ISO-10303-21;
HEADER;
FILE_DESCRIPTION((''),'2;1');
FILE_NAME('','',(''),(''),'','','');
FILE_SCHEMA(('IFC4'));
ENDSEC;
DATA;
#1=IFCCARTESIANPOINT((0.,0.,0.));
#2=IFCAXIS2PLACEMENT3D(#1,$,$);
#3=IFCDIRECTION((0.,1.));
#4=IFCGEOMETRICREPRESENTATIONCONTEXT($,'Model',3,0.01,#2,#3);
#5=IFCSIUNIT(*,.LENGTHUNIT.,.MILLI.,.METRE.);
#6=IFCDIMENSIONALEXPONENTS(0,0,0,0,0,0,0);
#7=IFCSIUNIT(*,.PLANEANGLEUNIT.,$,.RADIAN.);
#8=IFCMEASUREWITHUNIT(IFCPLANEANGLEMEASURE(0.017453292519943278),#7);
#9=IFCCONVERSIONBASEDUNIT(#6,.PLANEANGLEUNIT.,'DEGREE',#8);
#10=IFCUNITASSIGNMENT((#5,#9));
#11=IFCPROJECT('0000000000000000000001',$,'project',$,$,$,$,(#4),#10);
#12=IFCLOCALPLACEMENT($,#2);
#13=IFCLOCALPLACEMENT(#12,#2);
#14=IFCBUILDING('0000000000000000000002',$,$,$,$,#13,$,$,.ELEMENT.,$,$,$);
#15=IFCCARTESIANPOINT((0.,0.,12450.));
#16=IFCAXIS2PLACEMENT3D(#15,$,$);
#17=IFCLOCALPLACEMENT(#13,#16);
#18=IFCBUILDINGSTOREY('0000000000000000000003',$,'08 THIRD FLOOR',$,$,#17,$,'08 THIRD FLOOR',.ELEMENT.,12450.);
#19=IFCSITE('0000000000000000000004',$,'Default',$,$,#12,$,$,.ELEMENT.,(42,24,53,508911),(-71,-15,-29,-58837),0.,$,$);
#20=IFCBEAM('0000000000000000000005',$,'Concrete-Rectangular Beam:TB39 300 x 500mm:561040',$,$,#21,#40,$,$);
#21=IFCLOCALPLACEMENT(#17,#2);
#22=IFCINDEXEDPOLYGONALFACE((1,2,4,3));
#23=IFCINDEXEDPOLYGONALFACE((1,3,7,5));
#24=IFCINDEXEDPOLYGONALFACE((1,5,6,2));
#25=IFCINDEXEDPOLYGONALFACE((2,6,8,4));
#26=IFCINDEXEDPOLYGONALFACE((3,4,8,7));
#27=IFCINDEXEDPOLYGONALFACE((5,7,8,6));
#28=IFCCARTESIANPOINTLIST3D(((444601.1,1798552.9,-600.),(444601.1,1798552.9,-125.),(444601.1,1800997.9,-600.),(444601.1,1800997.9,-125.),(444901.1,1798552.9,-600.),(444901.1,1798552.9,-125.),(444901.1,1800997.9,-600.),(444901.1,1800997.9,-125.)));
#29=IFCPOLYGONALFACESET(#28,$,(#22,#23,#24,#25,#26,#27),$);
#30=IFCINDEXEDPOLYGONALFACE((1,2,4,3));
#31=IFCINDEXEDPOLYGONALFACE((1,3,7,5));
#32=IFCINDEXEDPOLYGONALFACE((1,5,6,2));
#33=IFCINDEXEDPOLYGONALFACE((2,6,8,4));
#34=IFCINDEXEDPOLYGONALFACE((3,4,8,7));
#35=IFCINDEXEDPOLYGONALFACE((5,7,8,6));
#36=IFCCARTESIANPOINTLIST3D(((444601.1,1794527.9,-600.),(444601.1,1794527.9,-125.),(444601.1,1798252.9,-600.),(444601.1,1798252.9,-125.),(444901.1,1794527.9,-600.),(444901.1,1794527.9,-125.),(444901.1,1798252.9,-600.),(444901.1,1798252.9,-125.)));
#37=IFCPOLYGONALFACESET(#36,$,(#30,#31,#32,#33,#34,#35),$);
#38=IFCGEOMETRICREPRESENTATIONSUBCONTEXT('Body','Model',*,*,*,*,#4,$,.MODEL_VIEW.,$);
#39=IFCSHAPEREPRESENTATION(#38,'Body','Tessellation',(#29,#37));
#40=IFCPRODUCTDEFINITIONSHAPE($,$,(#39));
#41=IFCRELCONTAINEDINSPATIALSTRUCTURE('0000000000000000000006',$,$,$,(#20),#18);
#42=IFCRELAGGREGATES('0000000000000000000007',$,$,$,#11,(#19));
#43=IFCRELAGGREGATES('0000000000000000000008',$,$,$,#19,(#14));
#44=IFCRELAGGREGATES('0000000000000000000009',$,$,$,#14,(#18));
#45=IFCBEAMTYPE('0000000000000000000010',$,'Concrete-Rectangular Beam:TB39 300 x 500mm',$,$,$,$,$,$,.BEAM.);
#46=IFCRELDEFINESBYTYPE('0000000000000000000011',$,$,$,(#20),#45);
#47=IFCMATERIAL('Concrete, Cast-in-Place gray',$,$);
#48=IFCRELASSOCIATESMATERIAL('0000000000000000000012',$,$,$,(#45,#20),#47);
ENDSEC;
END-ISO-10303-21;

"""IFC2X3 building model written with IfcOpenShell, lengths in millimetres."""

from ifc_helpers import new_model, entity, si_unit, converted_unit, direction, frame, frame_2d, origin, place, context, subcontext, project, spatial, rectangle, extrude, source, transform, mapped, material, type_object, type_shapes, element, save


model = new_model("IFC2X3")

# Units and contexts
model_context = context("Model", 3, precision=0.01, world=origin(), true_north=direction((0.0, 1.0)))
body_context = subcontext(model_context, "Body", "Model", "MODEL_VIEW")
ifc_project = project(units=[si_unit("LENGTHUNIT", "METRE", prefix="MILLI"), converted_unit("PLANEANGLEUNIT", "DEGREE", entity("IfcPlaneAngleMeasure", 0.017453292519943278), si_unit("PLANEANGLEUNIT", "RADIAN"), dimensions=[0, 0, 0, 0, 0, 0, 0])], contexts=[model_context])

# Site, building, storey
site_placement = place(None, origin())
site = spatial("IfcSite", under=ifc_project, at=site_placement, Name="Default", CompositionType="ELEMENT", RefLatitude=(42, 24, 53, 508911), RefLongitude=(-71, -15, -29, -58837), RefElevation=0.0)
building_placement = place(site_placement, origin())
building = spatial("IfcBuilding", under=site, at=building_placement, CompositionType="ELEMENT")
storey_placement = place(building_placement, frame((0.0, 0.0, 12450.0)))
storey = spatial("IfcBuildingStorey", under=building, at=storey_placement, Name="08 THIRD FLOOR", LongName="08 THIRD FLOOR", CompositionType="ELEMENT", Elevation=12450.0)

# Shared definitions
ifc_material = material(Name="Concrete, Cast-in-Place gray")

# Beam
beam_type_1 = type_object("IfcBeamType", Name="Concrete-Rectangular Beam:TB39 300 x 500mm", PredefinedType="BEAM", material=ifc_material)
shared_shape_1 = source(origin(), body_context, "Body", "SweptSolid", [
    extrude(rectangle(XDim=475.0, YDim=300.0, at=frame_2d((0.0, 0.0), x_axis=(0.0, 1.0))), frame((444751.1, 1800997.9, 12087.5), z_axis=(0.0, -1.0, 0.0), x_axis=(-1.0, 0.0, 0.0)), (0.0, 0.0, 1.0), 2445.0),
    extrude(rectangle(XDim=475.0, YDim=300.0, at=frame_2d((0.0, 0.0), x_axis=(0.0, 1.0))), frame((444751.1, 1798252.9, 12087.5), z_axis=(0.0, -1.0, 0.0), x_axis=(-1.0, 0.0, 0.0)), (0.0, 0.0, 1.0), 3725.0),
])
type_shapes(beam_type_1, [shared_shape_1])
beam_1_placement = place(storey_placement, frame((0.0, 0.0, -12450.0)))
element("IfcBeam", 1, at=beam_1_placement, inside=storey, type_object=beam_type_1, material=ifc_material, Name="Concrete-Rectangular Beam:TB39 300 x 500mm:561040", context=body_context, shape_type="MappedRepresentation", body=[
    mapped(shared_shape_1, transform((0.0, 0.0, 0.0), scale=1.0)),
])

save(model, "model.ifc")
